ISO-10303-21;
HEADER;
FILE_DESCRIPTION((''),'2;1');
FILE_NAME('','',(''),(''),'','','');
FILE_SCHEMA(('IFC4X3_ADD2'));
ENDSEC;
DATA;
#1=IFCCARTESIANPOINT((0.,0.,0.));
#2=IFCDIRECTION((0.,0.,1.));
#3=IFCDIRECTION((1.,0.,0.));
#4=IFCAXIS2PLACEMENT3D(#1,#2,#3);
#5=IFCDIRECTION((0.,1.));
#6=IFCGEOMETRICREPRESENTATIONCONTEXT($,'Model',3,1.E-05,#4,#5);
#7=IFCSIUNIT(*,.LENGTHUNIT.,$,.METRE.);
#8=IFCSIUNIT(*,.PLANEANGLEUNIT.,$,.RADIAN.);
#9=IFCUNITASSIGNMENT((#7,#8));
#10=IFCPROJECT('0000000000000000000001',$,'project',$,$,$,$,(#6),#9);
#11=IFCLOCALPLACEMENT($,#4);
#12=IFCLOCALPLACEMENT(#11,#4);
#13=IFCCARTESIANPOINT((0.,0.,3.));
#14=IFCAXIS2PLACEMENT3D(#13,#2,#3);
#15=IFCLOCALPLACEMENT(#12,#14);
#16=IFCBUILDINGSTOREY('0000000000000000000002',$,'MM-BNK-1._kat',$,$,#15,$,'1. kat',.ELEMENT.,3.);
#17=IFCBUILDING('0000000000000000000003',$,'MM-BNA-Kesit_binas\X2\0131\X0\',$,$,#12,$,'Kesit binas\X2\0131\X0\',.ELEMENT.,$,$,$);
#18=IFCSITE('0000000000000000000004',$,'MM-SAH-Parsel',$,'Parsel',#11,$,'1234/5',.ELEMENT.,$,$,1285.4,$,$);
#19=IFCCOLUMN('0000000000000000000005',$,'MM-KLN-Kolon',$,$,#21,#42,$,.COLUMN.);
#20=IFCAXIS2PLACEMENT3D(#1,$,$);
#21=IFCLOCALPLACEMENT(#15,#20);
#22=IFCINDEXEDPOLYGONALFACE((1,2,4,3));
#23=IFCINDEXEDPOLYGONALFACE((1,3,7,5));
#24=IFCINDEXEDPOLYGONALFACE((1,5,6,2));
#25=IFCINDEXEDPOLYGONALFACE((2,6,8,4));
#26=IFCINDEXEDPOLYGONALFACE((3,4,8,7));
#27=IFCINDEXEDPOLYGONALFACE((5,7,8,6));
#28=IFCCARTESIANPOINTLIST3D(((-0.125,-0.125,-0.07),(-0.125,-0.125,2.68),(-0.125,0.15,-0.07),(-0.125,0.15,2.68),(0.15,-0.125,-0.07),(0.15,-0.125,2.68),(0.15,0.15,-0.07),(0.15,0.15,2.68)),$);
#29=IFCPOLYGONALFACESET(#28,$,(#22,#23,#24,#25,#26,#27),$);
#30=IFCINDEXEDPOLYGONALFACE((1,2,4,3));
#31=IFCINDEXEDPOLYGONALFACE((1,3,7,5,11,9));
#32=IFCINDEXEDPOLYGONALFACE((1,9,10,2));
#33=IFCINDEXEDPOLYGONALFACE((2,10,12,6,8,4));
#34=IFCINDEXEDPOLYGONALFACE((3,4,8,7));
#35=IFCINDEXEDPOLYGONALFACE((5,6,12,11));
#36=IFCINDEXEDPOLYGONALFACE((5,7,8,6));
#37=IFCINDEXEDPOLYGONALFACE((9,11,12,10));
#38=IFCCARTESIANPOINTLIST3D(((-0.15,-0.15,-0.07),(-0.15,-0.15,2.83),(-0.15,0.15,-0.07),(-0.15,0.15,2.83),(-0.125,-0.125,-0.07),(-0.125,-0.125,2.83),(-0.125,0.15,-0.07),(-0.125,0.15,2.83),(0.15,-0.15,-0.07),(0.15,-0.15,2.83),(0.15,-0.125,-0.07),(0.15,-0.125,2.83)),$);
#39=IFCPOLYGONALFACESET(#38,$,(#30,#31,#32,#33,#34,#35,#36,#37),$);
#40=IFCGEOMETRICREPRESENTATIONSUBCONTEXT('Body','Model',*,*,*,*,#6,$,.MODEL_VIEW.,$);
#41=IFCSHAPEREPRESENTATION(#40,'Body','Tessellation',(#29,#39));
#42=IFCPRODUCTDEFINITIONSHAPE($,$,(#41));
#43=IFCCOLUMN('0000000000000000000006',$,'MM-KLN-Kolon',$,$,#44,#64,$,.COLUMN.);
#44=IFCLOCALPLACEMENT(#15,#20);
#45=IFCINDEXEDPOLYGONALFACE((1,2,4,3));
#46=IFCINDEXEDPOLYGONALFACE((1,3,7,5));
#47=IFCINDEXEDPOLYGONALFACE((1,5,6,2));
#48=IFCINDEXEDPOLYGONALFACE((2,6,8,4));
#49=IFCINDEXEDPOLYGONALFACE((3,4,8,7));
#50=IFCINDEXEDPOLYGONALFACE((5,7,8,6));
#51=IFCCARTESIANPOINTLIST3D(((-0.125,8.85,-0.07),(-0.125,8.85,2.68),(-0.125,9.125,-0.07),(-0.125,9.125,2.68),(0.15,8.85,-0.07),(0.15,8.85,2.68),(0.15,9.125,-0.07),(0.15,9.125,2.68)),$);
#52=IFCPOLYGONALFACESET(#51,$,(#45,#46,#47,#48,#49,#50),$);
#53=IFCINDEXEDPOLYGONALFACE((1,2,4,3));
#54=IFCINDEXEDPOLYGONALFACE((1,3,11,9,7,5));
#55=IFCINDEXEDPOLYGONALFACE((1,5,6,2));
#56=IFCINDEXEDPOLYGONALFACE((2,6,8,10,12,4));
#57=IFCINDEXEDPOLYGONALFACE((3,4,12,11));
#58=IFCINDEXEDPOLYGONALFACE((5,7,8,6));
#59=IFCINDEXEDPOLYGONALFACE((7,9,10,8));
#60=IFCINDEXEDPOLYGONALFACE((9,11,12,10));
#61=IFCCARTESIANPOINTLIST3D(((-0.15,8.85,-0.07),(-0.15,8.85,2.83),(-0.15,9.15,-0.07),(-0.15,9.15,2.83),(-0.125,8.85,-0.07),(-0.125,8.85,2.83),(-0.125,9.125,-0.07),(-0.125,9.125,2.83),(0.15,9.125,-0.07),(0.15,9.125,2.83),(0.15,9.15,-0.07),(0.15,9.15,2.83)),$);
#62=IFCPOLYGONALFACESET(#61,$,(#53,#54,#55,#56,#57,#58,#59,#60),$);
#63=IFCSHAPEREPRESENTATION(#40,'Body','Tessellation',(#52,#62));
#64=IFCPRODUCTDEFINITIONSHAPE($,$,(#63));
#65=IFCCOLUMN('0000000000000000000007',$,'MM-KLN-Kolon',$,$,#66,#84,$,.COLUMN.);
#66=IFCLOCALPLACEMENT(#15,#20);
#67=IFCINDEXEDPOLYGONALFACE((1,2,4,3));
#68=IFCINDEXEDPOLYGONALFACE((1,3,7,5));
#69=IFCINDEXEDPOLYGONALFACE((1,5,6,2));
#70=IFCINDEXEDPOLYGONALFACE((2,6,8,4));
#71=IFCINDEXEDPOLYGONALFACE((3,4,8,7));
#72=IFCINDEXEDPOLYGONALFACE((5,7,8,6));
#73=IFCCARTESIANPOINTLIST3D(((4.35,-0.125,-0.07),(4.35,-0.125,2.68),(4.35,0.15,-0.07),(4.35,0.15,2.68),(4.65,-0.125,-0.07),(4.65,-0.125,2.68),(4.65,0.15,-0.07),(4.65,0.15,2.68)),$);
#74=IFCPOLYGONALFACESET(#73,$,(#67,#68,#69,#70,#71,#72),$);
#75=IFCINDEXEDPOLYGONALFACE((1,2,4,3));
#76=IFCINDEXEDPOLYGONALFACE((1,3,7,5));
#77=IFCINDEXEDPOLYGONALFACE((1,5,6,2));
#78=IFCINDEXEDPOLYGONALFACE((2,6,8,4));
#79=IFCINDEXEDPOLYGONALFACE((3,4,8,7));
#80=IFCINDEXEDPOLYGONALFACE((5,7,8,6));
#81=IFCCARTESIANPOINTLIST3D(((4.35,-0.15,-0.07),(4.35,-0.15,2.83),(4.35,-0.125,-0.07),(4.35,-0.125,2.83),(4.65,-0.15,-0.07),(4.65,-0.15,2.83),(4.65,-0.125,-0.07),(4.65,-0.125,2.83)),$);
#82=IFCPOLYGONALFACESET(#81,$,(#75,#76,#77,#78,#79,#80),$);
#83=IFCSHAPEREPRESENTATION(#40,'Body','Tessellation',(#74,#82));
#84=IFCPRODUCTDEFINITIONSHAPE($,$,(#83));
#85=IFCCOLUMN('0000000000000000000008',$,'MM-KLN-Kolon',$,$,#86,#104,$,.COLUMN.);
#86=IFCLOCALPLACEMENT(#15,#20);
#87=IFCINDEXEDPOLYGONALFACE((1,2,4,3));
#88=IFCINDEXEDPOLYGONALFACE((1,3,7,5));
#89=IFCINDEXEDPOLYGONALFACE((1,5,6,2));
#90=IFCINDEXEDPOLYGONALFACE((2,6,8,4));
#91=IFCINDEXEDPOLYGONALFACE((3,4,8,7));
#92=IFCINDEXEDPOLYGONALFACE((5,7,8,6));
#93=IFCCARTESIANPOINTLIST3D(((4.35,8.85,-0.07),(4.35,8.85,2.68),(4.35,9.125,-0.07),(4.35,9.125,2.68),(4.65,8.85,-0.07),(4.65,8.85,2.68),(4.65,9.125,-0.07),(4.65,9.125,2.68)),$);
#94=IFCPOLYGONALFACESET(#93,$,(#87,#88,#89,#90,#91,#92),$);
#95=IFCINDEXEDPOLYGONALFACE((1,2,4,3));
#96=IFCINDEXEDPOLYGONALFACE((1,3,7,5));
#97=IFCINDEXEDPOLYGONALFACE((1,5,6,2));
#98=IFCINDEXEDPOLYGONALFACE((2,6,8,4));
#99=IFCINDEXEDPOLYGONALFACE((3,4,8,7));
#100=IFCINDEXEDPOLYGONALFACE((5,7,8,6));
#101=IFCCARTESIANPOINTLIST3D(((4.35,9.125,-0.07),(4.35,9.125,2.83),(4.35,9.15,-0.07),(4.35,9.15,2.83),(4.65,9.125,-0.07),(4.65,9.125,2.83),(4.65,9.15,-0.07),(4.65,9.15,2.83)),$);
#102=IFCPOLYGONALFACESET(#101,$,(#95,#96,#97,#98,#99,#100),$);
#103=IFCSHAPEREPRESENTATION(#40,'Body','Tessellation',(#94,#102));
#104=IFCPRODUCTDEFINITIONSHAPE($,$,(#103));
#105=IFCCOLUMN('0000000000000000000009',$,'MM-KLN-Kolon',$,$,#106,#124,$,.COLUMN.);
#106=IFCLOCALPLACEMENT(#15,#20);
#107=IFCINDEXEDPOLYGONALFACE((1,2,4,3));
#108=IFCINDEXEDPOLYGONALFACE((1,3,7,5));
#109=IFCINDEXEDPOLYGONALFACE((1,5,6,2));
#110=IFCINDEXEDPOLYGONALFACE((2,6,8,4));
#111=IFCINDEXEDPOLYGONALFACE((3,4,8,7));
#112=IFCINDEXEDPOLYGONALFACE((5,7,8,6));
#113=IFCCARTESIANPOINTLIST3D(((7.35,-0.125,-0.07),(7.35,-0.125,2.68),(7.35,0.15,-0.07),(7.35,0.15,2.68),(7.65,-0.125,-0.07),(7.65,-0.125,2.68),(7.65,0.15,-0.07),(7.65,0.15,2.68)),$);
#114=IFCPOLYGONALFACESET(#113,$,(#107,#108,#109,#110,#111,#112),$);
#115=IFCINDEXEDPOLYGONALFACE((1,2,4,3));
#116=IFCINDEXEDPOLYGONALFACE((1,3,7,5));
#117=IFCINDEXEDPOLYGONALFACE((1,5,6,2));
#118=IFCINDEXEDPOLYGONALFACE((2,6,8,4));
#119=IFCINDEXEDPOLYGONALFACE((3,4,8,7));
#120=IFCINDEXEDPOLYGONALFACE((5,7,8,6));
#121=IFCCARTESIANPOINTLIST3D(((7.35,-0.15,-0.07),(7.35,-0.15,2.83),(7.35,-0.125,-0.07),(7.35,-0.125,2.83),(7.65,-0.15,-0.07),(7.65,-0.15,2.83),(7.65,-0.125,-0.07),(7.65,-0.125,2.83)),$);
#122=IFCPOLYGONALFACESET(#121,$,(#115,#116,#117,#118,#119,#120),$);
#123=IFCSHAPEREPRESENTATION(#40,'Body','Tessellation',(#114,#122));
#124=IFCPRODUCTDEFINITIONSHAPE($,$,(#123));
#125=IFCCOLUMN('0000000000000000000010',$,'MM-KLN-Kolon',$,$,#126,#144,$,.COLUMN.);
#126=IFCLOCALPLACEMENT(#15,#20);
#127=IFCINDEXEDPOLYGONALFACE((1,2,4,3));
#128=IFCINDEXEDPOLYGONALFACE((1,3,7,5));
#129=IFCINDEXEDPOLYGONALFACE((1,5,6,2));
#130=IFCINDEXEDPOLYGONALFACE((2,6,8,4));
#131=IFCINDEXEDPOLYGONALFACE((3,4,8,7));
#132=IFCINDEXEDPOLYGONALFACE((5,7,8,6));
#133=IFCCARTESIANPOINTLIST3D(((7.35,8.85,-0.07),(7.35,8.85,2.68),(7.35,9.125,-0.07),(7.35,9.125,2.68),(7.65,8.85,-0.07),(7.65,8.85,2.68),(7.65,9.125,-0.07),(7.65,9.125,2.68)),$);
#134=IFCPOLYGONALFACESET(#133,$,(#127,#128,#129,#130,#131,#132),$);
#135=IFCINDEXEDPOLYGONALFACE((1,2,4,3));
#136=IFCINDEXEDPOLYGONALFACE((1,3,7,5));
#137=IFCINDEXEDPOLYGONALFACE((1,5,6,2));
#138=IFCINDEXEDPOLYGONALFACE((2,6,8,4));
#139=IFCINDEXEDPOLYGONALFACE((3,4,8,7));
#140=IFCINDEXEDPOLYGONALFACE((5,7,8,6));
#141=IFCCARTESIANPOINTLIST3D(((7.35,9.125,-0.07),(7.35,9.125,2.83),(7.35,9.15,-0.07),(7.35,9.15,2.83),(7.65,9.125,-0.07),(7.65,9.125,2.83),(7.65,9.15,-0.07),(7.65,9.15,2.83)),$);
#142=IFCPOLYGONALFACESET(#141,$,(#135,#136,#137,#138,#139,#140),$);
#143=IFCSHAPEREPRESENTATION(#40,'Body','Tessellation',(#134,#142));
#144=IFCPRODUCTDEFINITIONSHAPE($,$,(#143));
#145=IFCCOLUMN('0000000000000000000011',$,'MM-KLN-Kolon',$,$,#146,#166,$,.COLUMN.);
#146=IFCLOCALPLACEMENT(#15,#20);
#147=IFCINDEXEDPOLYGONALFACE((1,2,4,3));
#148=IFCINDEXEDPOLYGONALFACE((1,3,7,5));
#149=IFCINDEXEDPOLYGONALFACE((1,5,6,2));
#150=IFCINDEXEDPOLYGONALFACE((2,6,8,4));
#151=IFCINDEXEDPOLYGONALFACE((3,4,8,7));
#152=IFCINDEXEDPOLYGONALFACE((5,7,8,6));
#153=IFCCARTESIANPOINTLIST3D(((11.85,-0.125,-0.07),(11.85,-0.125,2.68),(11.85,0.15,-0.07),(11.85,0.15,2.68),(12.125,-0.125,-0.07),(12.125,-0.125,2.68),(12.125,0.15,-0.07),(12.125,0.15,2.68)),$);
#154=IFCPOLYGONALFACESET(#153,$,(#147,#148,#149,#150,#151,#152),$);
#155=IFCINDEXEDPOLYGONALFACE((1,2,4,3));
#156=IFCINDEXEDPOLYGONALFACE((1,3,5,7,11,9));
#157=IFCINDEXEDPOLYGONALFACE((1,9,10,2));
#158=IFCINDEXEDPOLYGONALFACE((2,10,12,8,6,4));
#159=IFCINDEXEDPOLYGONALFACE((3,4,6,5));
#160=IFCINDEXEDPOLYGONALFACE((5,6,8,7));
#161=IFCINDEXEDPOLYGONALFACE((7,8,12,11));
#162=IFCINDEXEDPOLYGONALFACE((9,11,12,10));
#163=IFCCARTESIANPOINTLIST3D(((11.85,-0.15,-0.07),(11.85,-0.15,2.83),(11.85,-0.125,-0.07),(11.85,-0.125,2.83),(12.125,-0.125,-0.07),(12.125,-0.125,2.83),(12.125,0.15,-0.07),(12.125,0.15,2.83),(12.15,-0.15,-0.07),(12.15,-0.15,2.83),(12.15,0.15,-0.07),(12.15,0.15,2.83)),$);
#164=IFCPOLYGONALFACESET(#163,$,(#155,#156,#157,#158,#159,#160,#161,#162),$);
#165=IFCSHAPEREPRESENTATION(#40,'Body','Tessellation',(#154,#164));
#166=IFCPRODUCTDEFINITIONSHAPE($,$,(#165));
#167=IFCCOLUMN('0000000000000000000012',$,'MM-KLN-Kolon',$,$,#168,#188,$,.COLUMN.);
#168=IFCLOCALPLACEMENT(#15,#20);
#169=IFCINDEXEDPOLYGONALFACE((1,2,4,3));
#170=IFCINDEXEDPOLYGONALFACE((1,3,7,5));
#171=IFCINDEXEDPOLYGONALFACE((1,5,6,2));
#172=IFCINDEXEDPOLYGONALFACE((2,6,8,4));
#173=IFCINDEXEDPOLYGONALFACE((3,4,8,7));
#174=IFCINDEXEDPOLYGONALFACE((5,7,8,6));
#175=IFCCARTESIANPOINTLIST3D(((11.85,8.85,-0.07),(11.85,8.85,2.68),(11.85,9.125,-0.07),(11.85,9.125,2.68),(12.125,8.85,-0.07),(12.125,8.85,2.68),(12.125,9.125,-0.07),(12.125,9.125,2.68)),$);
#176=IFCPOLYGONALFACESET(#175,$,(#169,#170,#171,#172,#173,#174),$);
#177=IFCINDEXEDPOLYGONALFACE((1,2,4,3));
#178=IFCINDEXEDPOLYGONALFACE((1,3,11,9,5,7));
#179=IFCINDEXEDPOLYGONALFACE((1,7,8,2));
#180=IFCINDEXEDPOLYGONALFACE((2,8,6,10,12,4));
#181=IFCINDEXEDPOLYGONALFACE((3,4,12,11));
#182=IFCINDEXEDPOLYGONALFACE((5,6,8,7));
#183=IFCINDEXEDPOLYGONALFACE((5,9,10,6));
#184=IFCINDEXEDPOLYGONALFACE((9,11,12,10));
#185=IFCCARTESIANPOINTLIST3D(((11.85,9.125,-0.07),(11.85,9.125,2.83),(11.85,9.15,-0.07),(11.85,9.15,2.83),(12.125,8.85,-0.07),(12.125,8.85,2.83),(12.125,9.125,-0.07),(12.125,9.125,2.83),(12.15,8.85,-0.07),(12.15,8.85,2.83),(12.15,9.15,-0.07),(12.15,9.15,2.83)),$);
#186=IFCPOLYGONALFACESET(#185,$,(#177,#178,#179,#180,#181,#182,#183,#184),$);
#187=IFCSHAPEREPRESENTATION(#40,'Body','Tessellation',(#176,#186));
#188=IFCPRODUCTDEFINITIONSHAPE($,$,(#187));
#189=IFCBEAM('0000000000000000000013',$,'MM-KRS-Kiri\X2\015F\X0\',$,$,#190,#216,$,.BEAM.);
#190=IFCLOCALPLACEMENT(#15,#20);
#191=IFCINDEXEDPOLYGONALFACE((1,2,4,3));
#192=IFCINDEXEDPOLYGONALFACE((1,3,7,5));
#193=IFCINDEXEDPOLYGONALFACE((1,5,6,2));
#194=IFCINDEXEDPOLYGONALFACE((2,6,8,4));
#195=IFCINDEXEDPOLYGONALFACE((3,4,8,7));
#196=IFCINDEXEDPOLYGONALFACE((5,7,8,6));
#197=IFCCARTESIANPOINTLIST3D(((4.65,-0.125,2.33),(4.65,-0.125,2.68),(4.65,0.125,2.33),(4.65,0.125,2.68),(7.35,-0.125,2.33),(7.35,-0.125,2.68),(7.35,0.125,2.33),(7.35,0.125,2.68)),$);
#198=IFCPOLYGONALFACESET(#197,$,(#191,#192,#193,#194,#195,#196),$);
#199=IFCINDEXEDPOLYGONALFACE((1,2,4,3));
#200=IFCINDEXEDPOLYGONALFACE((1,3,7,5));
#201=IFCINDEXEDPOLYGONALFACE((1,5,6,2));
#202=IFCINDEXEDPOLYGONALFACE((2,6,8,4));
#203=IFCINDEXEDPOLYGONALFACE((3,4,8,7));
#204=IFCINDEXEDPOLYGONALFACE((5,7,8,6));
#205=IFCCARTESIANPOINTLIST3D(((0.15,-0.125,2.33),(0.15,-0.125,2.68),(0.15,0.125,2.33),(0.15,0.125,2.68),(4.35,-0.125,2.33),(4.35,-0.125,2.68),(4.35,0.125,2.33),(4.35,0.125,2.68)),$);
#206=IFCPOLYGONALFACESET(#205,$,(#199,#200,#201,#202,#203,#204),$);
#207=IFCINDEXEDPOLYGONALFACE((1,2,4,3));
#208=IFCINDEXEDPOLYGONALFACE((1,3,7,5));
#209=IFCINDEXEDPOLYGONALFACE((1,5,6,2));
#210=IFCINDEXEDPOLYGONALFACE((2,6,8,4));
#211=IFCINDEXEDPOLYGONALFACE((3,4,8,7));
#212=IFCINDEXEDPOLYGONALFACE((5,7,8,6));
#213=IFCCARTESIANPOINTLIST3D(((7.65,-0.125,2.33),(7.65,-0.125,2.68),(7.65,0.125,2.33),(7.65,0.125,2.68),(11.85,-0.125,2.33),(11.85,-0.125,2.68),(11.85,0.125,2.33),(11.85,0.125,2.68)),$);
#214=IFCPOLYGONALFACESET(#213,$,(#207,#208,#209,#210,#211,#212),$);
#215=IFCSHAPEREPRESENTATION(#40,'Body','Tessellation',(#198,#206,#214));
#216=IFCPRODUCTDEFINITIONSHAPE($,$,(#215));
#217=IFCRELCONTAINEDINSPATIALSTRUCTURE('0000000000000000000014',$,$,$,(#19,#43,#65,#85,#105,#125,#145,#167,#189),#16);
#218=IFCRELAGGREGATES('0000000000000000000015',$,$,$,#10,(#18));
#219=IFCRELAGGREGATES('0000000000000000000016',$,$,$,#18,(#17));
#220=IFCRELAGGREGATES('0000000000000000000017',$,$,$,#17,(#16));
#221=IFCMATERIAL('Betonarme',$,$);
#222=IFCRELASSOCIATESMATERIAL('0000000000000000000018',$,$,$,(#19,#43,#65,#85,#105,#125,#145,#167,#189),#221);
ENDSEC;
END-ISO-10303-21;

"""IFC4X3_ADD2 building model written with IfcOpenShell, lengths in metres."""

from ifc_helpers import new_model, si_unit, direction, frame, origin_with_axes, place, context, subcontext, project, spatial, polyline, outline, extrude, material, element, save


model = new_model("IFC4X3_ADD2")

# Units and contexts
model_context = context("Model", 3, precision=1e-05, world=origin_with_axes(), true_north=direction((0.0, 1.0)))
body_context = subcontext(model_context, "Body", "Model", "MODEL_VIEW")
ifc_project = project(units=[si_unit("LENGTHUNIT", "METRE"), si_unit("PLANEANGLEUNIT", "RADIAN")], contexts=[model_context])

# Site, building, storey
site_placement = place(None, origin_with_axes())
site = spatial("IfcSite", under=ifc_project, at=site_placement, Name="MM-SAH-Parsel", ObjectType="Parsel", LongName="1234/5", CompositionType="ELEMENT", RefElevation=1285.4)
building_placement = place(site_placement, origin_with_axes())
building = spatial("IfcBuilding", under=site, at=building_placement, Name="MM-BNA-Kesit_binası", LongName="Kesit binası", CompositionType="ELEMENT")
storey_placement = place(building_placement, frame((0.0, 0.0, 3.0), z_axis=(0.0, 0.0, 1.0), x_axis=(1.0, 0.0, 0.0)))
storey = spatial("IfcBuildingStorey", under=building, at=storey_placement, Name="MM-BNK-1._kat", LongName="1. kat", CompositionType="ELEMENT", Elevation=3.0)

# Columns
ifc_material_1 = material(Name="Betonarme")
column_1_placement = place(storey_placement, origin_with_axes())
element("IfcColumn", 1, at=column_1_placement, inside=storey, material=ifc_material_1, Name="MM-KLN-Kolon", PredefinedType="COLUMN", context=body_context, shape_type="SweptSolid", body=[
    extrude(outline(polyline([(0.15, -0.125), (0.15, 0.15), (-0.125, 0.15), (-0.125, -0.125), (0.15, -0.125)])), frame((0.0, 0.0, -0.07)), (0.0, 0.0, 1.0), 2.75),
    extrude(outline(polyline([(-0.15, -0.15), (0.15, -0.15), (0.15, -0.125), (-0.125, -0.125), (-0.125, 0.15), (-0.15, 0.15), (-0.15, -0.15)])), frame((0.0, 0.0, -0.07)), (0.0, 0.0, 1.0), 2.9),
])
column_2_placement = place(storey_placement, origin_with_axes())
element("IfcColumn", 2, at=column_2_placement, inside=storey, material=ifc_material_1, Name="MM-KLN-Kolon", PredefinedType="COLUMN", context=body_context, shape_type="SweptSolid", body=[
    extrude(outline(polyline([(-0.125, 8.85), (0.15, 8.85), (0.15, 9.125), (-0.125, 9.125), (-0.125, 8.85)])), frame((0.0, 0.0, -0.07)), (0.0, 0.0, 1.0), 2.75),
    extrude(outline(polyline([(-0.15, 8.85), (-0.125, 8.85), (-0.125, 9.125), (0.15, 9.125), (0.15, 9.15), (-0.15, 9.15), (-0.15, 8.85)])), frame((0.0, 0.0, -0.07)), (0.0, 0.0, 1.0), 2.9),
])
column_3_placement = place(storey_placement, origin_with_axes())
element("IfcColumn", 3, at=column_3_placement, inside=storey, material=ifc_material_1, Name="MM-KLN-Kolon", PredefinedType="COLUMN", context=body_context, shape_type="SweptSolid", body=[
    extrude(outline(polyline([(4.65, -0.125), (4.65, 0.15), (4.35, 0.15), (4.35, -0.125), (4.65, -0.125)])), frame((0.0, 0.0, -0.07)), (0.0, 0.0, 1.0), 2.75),
    extrude(outline(polyline([(4.35, -0.15), (4.65, -0.15), (4.65, -0.125), (4.35, -0.125), (4.35, -0.15)])), frame((0.0, 0.0, -0.07)), (0.0, 0.0, 1.0), 2.9),
])
column_4_placement = place(storey_placement, origin_with_axes())
element("IfcColumn", 4, at=column_4_placement, inside=storey, material=ifc_material_1, Name="MM-KLN-Kolon", PredefinedType="COLUMN", context=body_context, shape_type="SweptSolid", body=[
    extrude(outline(polyline([(4.35, 8.85), (4.65, 8.85), (4.65, 9.125), (4.35, 9.125), (4.35, 8.85)])), frame((0.0, 0.0, -0.07)), (0.0, 0.0, 1.0), 2.75),
    extrude(outline(polyline([(4.65, 9.125), (4.65, 9.15), (4.35, 9.15), (4.35, 9.125), (4.65, 9.125)])), frame((0.0, 0.0, -0.07)), (0.0, 0.0, 1.0), 2.9),
])
column_5_placement = place(storey_placement, origin_with_axes())
element("IfcColumn", 5, at=column_5_placement, inside=storey, material=ifc_material_1, Name="MM-KLN-Kolon", PredefinedType="COLUMN", context=body_context, shape_type="SweptSolid", body=[
    extrude(outline(polyline([(7.65, -0.125), (7.65, 0.15), (7.35, 0.15), (7.35, -0.125), (7.65, -0.125)])), frame((0.0, 0.0, -0.07)), (0.0, 0.0, 1.0), 2.75),
    extrude(outline(polyline([(7.35, -0.15), (7.65, -0.15), (7.65, -0.125), (7.35, -0.125), (7.35, -0.15)])), frame((0.0, 0.0, -0.07)), (0.0, 0.0, 1.0), 2.9),
])
column_6_placement = place(storey_placement, origin_with_axes())
element("IfcColumn", 6, at=column_6_placement, inside=storey, material=ifc_material_1, Name="MM-KLN-Kolon", PredefinedType="COLUMN", context=body_context, shape_type="SweptSolid", body=[
    extrude(outline(polyline([(7.35, 8.85), (7.65, 8.85), (7.65, 9.125), (7.35, 9.125), (7.35, 8.85)])), frame((0.0, 0.0, -0.07)), (0.0, 0.0, 1.0), 2.75),
    extrude(outline(polyline([(7.65, 9.125), (7.65, 9.15), (7.35, 9.15), (7.35, 9.125), (7.65, 9.125)])), frame((0.0, 0.0, -0.07)), (0.0, 0.0, 1.0), 2.9),
])
column_7_placement = place(storey_placement, origin_with_axes())
element("IfcColumn", 7, at=column_7_placement, inside=storey, material=ifc_material_1, Name="MM-KLN-Kolon", PredefinedType="COLUMN", context=body_context, shape_type="SweptSolid", body=[
    extrude(outline(polyline([(12.125, 0.15), (11.85, 0.15), (11.85, -0.125), (12.125, -0.125), (12.125, 0.15)])), frame((0.0, 0.0, -0.07)), (0.0, 0.0, 1.0), 2.75),
    extrude(outline(polyline([(11.85, -0.15), (12.15, -0.15), (12.15, 0.15), (12.125, 0.15), (12.125, -0.125), (11.85, -0.125), (11.85, -0.15)])), frame((0.0, 0.0, -0.07)), (0.0, 0.0, 1.0), 2.9),
])
column_8_placement = place(storey_placement, origin_with_axes())
element("IfcColumn", 8, at=column_8_placement, inside=storey, material=ifc_material_1, Name="MM-KLN-Kolon", PredefinedType="COLUMN", context=body_context, shape_type="SweptSolid", body=[
    extrude(outline(polyline([(11.85, 8.85), (12.125, 8.85), (12.125, 9.125), (11.85, 9.125), (11.85, 8.85)])), frame((0.0, 0.0, -0.07)), (0.0, 0.0, 1.0), 2.75),
    extrude(outline(polyline([(12.125, 8.85), (12.15, 8.85), (12.15, 9.15), (11.85, 9.15), (11.85, 9.125), (12.125, 9.125), (12.125, 8.85)])), frame((0.0, 0.0, -0.07)), (0.0, 0.0, 1.0), 2.9),
])

# Beam
beam_1_placement = place(storey_placement, origin_with_axes())
element("IfcBeam", 9, at=beam_1_placement, inside=storey, material=ifc_material_1, Name="MM-KRS-Kiriş", PredefinedType="BEAM", context=body_context, shape_type="SweptSolid", body=[
    extrude(outline(polyline([(4.65, -0.125), (7.35, -0.125), (7.35, 0.125), (4.65, 0.125), (4.65, -0.125)])), frame((0.0, 0.0, 2.33)), (0.0, 0.0, 1.0), 0.35),
    extrude(outline(polyline([(0.15, -0.125), (4.35, -0.125), (4.35, 0.125), (0.15, 0.125), (0.15, -0.125)])), frame((0.0, 0.0, 2.33)), (0.0, 0.0, 1.0), 0.35),
    extrude(outline(polyline([(7.65, -0.125), (11.85, -0.125), (11.85, 0.125), (7.65, 0.125), (7.65, -0.125)])), frame((0.0, 0.0, 2.33)), (0.0, 0.0, 1.0), 0.35),
])

save(model, "model.ifc")
